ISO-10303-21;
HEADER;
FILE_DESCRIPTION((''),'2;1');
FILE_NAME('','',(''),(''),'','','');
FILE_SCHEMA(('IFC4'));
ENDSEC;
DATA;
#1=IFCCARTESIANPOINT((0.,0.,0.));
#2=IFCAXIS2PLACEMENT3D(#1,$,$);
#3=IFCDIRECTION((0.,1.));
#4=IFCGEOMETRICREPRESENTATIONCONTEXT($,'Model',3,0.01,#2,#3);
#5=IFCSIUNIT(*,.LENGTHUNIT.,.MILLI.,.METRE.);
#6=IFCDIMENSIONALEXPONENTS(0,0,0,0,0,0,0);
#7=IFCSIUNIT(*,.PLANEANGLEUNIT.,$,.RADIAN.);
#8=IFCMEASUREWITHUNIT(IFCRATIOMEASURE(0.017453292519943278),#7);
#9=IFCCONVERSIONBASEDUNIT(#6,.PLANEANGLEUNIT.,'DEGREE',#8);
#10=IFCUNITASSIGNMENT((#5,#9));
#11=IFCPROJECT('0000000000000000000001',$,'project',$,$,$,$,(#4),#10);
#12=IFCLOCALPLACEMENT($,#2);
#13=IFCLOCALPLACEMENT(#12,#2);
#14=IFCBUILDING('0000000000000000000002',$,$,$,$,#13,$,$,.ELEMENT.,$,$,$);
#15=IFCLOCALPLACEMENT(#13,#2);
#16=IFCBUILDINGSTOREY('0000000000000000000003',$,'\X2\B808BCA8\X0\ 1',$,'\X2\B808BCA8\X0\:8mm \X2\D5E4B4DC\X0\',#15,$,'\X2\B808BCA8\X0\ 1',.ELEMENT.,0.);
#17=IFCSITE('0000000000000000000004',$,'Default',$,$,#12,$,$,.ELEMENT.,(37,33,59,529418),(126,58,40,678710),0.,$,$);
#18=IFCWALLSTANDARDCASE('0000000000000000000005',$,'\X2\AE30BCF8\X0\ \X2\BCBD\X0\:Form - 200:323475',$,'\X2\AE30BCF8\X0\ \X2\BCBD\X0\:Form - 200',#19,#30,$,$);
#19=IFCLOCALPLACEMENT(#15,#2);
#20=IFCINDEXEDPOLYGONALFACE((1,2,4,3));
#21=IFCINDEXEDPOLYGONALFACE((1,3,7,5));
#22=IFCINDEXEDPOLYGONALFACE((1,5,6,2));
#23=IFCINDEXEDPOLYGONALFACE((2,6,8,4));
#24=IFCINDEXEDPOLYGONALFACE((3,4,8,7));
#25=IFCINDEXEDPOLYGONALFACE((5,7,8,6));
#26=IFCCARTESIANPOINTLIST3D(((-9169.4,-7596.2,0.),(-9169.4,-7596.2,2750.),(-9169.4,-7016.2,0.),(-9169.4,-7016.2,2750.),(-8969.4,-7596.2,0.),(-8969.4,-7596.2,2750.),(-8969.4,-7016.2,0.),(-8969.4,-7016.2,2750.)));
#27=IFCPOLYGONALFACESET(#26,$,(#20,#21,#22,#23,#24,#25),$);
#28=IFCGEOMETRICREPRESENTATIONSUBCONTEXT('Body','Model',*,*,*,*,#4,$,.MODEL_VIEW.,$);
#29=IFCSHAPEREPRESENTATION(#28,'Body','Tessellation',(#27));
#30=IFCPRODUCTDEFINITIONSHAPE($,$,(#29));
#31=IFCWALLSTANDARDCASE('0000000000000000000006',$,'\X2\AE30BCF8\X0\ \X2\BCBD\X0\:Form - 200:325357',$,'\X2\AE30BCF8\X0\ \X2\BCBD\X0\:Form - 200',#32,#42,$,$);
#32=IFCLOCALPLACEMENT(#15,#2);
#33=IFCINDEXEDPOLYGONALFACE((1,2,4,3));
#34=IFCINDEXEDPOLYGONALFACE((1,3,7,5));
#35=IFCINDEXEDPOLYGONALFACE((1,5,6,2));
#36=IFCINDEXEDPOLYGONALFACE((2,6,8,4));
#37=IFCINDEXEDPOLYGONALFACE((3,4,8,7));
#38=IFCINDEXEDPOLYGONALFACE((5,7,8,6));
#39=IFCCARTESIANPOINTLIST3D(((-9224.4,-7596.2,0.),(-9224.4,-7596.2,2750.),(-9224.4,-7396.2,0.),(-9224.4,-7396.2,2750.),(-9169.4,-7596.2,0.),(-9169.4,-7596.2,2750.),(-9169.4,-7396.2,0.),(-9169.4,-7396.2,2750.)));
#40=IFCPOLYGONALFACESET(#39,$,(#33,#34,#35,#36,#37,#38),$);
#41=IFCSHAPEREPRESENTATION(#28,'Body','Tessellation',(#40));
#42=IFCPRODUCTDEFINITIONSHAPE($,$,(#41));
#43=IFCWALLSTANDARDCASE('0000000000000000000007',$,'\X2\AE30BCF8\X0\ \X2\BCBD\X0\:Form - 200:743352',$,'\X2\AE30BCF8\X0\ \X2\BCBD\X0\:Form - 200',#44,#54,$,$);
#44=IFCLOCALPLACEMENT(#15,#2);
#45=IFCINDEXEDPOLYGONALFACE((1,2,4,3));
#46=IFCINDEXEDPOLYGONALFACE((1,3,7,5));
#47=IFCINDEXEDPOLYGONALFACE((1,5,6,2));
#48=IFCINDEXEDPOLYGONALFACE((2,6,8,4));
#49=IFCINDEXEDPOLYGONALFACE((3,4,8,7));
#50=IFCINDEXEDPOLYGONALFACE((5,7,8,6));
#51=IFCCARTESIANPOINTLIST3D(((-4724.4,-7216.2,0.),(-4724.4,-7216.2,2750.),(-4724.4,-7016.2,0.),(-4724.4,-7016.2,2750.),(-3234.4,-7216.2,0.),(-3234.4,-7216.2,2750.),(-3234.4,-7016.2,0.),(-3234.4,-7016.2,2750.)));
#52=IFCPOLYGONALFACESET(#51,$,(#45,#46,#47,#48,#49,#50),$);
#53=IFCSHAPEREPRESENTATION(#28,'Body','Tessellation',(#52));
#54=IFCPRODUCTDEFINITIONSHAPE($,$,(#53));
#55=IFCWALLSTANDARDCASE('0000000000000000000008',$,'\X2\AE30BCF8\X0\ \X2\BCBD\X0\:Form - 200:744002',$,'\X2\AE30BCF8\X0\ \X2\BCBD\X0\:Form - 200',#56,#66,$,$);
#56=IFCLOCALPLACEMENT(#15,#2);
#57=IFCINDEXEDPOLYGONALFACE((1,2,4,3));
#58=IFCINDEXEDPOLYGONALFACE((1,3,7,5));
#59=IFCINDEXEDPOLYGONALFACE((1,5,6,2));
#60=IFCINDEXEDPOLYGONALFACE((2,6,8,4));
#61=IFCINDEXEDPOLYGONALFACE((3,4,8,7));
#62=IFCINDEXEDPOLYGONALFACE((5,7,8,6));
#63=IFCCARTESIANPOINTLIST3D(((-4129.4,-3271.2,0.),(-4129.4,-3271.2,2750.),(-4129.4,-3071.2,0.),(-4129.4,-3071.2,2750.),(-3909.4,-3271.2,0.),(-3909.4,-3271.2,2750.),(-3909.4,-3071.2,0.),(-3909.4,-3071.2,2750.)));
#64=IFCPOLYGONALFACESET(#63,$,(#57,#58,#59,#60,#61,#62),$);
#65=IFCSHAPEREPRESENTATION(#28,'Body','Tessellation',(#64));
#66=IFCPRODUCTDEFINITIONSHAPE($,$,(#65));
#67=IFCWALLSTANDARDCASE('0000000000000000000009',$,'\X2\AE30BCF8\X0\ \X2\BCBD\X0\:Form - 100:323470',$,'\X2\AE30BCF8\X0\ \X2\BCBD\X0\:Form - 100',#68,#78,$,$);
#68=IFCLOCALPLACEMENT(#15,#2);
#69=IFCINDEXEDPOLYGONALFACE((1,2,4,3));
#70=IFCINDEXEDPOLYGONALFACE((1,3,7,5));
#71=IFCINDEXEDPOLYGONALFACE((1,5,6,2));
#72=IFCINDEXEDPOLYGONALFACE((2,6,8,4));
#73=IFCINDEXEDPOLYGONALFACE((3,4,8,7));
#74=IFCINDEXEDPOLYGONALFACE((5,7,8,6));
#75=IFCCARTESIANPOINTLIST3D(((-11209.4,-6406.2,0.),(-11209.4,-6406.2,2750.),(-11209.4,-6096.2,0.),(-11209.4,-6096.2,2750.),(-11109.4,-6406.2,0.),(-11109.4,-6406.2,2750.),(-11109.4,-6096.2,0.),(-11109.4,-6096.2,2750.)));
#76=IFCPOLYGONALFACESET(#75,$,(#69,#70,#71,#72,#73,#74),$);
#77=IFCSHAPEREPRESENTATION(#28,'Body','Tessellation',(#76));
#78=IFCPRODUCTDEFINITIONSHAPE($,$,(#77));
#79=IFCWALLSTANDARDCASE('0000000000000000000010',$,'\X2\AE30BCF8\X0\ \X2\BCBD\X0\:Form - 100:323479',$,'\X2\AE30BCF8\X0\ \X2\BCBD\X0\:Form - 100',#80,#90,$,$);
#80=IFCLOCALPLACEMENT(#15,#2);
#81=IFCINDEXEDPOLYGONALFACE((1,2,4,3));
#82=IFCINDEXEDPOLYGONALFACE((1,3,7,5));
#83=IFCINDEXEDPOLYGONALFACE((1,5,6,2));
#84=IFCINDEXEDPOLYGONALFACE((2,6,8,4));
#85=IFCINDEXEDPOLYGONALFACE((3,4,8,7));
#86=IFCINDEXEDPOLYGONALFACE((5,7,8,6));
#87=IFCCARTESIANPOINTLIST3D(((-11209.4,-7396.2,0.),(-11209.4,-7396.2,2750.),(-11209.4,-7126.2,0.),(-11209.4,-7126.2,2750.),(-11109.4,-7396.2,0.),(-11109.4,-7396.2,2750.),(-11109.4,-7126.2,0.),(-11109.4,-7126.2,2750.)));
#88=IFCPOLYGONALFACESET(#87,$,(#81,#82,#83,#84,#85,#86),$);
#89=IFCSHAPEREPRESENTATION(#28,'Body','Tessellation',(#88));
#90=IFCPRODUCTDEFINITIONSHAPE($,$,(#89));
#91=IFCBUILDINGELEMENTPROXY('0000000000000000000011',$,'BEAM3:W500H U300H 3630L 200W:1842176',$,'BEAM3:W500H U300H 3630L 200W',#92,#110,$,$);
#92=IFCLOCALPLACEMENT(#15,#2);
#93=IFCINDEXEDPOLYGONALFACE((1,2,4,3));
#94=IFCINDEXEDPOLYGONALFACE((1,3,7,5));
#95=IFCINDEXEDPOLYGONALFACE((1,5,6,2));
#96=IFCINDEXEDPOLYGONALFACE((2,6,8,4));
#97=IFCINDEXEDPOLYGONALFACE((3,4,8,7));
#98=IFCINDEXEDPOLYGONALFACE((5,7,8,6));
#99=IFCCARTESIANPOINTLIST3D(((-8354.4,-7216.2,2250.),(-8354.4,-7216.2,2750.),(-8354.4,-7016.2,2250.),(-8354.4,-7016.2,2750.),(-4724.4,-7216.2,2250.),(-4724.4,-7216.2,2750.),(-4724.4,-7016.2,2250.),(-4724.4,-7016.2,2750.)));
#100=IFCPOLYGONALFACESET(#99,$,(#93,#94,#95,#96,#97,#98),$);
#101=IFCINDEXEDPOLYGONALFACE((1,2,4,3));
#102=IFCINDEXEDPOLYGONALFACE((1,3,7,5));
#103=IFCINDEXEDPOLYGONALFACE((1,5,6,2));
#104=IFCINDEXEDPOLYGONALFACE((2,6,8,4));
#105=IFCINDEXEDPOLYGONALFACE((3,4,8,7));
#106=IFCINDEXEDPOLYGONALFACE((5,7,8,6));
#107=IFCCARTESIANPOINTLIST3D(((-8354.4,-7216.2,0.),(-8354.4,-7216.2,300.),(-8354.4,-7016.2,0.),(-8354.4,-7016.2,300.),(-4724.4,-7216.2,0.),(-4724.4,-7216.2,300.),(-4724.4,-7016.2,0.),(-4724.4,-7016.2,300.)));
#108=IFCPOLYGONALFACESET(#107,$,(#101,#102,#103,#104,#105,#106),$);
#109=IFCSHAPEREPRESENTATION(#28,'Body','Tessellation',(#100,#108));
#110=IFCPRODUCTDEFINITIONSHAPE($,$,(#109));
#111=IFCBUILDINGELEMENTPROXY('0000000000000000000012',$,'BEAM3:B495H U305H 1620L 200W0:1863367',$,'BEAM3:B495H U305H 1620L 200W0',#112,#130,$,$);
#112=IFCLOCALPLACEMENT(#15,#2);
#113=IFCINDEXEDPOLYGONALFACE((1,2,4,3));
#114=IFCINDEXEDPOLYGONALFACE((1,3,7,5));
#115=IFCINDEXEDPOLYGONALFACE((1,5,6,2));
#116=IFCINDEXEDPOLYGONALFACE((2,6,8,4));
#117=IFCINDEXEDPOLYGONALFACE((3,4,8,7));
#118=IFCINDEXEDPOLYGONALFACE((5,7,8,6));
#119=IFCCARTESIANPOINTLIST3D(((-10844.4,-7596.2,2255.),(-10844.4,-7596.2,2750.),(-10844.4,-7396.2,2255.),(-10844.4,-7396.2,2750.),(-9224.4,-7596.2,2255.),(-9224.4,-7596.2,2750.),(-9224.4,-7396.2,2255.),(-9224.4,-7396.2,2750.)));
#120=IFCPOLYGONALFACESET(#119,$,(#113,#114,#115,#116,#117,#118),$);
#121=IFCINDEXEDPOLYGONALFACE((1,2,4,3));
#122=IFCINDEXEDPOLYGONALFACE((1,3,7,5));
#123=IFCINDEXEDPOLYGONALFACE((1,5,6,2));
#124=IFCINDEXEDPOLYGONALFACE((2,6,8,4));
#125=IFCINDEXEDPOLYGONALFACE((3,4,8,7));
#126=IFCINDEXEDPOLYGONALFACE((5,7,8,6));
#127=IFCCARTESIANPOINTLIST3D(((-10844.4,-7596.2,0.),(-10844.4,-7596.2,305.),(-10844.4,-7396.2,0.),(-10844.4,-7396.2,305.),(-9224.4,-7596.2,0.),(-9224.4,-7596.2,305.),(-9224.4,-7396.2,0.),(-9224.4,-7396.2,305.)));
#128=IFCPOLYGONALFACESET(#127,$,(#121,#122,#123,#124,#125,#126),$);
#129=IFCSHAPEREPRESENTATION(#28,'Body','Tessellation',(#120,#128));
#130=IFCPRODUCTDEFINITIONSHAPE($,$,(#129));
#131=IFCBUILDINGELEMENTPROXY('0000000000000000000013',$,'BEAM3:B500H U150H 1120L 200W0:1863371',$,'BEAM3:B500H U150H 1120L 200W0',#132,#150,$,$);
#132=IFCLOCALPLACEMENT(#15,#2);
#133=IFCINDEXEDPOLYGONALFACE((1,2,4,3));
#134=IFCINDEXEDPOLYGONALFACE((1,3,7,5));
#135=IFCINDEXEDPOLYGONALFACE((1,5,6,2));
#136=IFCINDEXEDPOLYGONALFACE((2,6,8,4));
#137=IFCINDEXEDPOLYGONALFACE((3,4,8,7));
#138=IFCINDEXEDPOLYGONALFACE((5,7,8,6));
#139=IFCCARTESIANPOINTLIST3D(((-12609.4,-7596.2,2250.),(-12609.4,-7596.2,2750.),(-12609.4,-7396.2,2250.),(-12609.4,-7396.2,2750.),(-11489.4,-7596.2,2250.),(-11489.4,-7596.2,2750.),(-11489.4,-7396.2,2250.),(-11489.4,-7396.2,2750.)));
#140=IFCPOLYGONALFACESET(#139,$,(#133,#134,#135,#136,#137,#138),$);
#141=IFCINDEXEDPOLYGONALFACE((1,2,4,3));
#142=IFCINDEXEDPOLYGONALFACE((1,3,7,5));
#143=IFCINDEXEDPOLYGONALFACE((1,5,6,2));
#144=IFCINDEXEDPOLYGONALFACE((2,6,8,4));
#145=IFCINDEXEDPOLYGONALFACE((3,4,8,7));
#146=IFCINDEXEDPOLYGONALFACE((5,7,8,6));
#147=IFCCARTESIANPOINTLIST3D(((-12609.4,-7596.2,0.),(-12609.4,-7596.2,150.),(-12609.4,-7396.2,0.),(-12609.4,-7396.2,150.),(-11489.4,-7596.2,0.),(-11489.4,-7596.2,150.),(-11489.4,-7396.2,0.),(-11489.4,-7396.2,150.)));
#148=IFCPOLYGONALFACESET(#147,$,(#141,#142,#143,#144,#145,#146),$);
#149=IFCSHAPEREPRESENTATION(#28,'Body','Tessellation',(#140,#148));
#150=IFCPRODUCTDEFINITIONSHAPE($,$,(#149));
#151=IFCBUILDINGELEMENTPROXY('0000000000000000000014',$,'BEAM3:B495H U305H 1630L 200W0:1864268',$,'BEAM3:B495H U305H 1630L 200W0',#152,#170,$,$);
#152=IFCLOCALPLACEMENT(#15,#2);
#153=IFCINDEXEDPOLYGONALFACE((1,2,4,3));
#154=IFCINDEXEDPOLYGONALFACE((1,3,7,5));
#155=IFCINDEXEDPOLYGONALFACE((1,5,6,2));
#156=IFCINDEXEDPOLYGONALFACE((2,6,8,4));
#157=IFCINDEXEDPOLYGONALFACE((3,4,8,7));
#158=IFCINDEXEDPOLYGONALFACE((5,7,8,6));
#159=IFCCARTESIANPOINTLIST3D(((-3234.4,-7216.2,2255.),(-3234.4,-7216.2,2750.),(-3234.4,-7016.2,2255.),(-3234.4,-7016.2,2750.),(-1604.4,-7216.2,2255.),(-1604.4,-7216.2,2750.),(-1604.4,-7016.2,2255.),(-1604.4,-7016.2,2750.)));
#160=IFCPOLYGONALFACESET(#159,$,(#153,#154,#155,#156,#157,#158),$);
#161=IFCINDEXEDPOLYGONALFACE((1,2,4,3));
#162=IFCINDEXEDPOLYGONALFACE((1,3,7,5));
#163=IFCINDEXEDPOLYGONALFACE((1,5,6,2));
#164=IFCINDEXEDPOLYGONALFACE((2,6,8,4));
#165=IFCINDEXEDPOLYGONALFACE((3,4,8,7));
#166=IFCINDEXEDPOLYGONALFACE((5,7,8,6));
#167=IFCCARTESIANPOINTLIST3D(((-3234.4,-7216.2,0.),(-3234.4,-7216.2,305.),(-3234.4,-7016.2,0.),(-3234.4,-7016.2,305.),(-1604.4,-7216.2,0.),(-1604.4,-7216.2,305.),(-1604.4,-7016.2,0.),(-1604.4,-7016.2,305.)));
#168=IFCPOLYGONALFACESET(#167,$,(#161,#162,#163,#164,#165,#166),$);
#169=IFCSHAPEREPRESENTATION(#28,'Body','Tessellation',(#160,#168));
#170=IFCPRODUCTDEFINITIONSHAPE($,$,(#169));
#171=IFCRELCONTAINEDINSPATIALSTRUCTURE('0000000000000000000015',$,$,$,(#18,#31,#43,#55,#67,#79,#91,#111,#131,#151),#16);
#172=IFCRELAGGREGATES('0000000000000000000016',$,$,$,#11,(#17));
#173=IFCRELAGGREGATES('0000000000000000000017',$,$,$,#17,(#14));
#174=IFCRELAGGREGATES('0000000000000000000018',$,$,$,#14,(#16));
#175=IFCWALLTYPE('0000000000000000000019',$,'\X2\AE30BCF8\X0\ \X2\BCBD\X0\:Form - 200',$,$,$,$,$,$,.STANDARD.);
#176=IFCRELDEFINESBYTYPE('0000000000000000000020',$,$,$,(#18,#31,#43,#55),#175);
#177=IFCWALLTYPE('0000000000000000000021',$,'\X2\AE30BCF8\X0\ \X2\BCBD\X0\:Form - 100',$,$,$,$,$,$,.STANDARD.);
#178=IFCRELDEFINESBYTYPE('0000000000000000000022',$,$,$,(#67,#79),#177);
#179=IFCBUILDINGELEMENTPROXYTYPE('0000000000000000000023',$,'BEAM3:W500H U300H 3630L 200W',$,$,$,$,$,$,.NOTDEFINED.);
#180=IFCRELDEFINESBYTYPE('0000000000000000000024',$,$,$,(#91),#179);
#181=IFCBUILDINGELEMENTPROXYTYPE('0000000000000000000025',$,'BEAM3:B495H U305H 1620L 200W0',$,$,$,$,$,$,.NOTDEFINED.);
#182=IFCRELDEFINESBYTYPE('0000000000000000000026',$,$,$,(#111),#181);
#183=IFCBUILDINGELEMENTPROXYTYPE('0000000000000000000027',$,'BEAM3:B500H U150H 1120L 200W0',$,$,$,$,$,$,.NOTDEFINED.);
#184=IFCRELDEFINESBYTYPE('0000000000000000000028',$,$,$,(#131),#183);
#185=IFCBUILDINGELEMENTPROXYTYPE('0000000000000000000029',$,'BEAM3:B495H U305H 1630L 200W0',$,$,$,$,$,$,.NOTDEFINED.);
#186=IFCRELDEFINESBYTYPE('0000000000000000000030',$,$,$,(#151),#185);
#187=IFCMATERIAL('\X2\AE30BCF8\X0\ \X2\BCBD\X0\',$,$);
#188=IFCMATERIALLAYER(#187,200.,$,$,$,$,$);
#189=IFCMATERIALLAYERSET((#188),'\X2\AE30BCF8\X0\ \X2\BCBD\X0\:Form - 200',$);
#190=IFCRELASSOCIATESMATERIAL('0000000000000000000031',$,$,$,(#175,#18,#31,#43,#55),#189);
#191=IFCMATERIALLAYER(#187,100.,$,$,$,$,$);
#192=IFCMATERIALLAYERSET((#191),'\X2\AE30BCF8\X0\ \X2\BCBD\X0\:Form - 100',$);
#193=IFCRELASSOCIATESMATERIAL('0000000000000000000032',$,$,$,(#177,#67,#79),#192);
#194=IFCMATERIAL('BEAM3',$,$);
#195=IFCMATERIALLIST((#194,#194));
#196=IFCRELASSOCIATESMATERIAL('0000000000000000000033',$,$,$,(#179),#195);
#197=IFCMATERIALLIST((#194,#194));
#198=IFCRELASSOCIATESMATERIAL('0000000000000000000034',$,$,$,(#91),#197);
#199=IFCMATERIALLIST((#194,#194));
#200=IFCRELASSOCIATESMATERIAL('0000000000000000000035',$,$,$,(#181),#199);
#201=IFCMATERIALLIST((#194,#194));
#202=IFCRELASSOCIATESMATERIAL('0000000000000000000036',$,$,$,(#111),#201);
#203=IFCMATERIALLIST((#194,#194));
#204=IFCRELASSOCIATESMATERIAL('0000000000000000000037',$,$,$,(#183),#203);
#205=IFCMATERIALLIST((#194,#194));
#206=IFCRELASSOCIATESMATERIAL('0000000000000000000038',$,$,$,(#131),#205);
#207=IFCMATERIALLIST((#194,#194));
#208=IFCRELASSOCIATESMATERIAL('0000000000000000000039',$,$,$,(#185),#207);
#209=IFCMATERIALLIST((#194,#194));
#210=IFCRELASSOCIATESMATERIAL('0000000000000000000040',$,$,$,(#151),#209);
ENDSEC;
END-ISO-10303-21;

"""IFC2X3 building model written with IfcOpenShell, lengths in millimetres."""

from ifc_helpers import new_model, entity, si_unit, converted_unit, direction, frame, frame_2d, origin, origin_2d_with_axis, place, context, subcontext, project, spatial, rectangle, extrude, source, transform, mapped, material, material_list, layer, layer_set, layer_usage, type_object, type_shapes, element, save


model = new_model("IFC2X3")

# Units and contexts
model_context = context("Model", 3, precision=0.01, world=origin(), true_north=direction((0.0, 1.0)))
body_context = subcontext(model_context, "Body", "Model", "MODEL_VIEW")
ifc_project = project(units=[si_unit("LENGTHUNIT", "METRE", prefix="MILLI"), converted_unit("PLANEANGLEUNIT", "DEGREE", entity("IfcRatioMeasure", 0.017453292519943278), si_unit("PLANEANGLEUNIT", "RADIAN"), dimensions=[0, 0, 0, 0, 0, 0, 0])], contexts=[model_context])

# Site, building, storey
site_placement = place(None, origin())
site = spatial("IfcSite", under=ifc_project, at=site_placement, Name="Default", CompositionType="ELEMENT", RefLatitude=(37, 33, 59, 529418), RefLongitude=(126, 58, 40, 678710), RefElevation=0.0)
building_placement = place(site_placement, origin())
building = spatial("IfcBuilding", under=site, at=building_placement, CompositionType="ELEMENT")
storey_placement = place(building_placement, origin())
storey = spatial("IfcBuildingStorey", under=building, at=storey_placement, Name="레벨 1", ObjectType="레벨:8mm 헤드", LongName="레벨 1", CompositionType="ELEMENT", Elevation=0.0)

# Walls
ifc_material_1 = material(Name="기본 벽")
ifc_layer_1 = layer(ifc_material_1, 200.0)
ifc_layer_set_1 = layer_set([ifc_layer_1], Name="기본 벽:Form - 200")
wall_type_1 = type_object("IfcWallType", Name="기본 벽:Form - 200", PredefinedType="STANDARD", material=ifc_layer_set_1)
ifc_layer_usage_1 = layer_usage(ifc_layer_set_1, "AXIS2", "POSITIVE", -100.0)
wall_1_placement = place(storey_placement, frame((-9069.4, -7596.2, 0.0), z_axis=(0.0, 0.0, 1.0), x_axis=(0.0, 1.0, 0.0)))
element("IfcWallStandardCase", 1, at=wall_1_placement, inside=storey, type_object=wall_type_1, material=ifc_layer_usage_1, Name="기본 벽:Form - 200:323475", ObjectType="기본 벽:Form - 200", context=body_context, shape_type="SweptSolid", body=[
    extrude(rectangle(XDim=580.0, YDim=200.0, at=frame_2d((290.0, 0.0), x_axis=(-1.0, 0.0))), origin(), (0.0, 0.0, 1.0), 2750.0),
])
ifc_layer_usage_2 = layer_usage(ifc_layer_set_1, "AXIS2", "POSITIVE", -100.0)
wall_2_placement = place(storey_placement, frame((-9224.4, -7496.2, 0.0)))
element("IfcWallStandardCase", 2, at=wall_2_placement, inside=storey, type_object=wall_type_1, material=ifc_layer_usage_2, Name="기본 벽:Form - 200:325357", ObjectType="기본 벽:Form - 200", context=body_context, shape_type="SweptSolid", body=[
    extrude(rectangle(XDim=55.0, YDim=200.0, at=frame_2d((27.5, 0.0), x_axis=(-1.0, 0.0))), origin(), (0.0, 0.0, 1.0), 2750.0),
])
ifc_layer_usage_3 = layer_usage(ifc_layer_set_1, "AXIS2", "POSITIVE", -100.0)
wall_3_placement = place(storey_placement, frame((-4724.4, -7116.2, 0.0)))
element("IfcWallStandardCase", 3, at=wall_3_placement, inside=storey, type_object=wall_type_1, material=ifc_layer_usage_3, Name="기본 벽:Form - 200:743352", ObjectType="기본 벽:Form - 200", context=body_context, shape_type="SweptSolid", body=[
    extrude(rectangle(XDim=1490.0, YDim=200.0, at=frame_2d((745.0, 0.0), x_axis=(-1.0, 0.0))), origin(), (0.0, 0.0, 1.0), 2750.0),
])
ifc_layer_usage_4 = layer_usage(ifc_layer_set_1, "AXIS2", "POSITIVE", -100.0)
wall_4_placement = place(storey_placement, frame((-3909.4, -3171.2, 0.0), z_axis=(0.0, 0.0, 1.0), x_axis=(-1.0, 0.0, 0.0)))
element("IfcWallStandardCase", 4, at=wall_4_placement, inside=storey, type_object=wall_type_1, material=ifc_layer_usage_4, Name="기본 벽:Form - 200:744002", ObjectType="기본 벽:Form - 200", context=body_context, shape_type="SweptSolid", body=[
    extrude(rectangle(XDim=220.0, YDim=200.0, at=frame_2d((110.0, 0.0), x_axis=(-1.0, 0.0))), origin(), (0.0, 0.0, 1.0), 2750.0),
])
ifc_layer_2 = layer(ifc_material_1, 100.0)
ifc_layer_set_2 = layer_set([ifc_layer_2], Name="기본 벽:Form - 100")
ifc_layer_usage_5 = layer_usage(ifc_layer_set_2, "AXIS2", "POSITIVE", -50.0)
wall_type_2 = type_object("IfcWallType", Name="기본 벽:Form - 100", PredefinedType="STANDARD", material=ifc_layer_set_2)
wall_5_placement = place(storey_placement, frame((-11159.4, -6096.2, 0.0), z_axis=(0.0, 0.0, 1.0), x_axis=(0.0, -1.0, 0.0)))
element("IfcWallStandardCase", 5, at=wall_5_placement, inside=storey, type_object=wall_type_2, material=ifc_layer_usage_5, Name="기본 벽:Form - 100:323470", ObjectType="기본 벽:Form - 100", context=body_context, shape_type="SweptSolid", body=[
    extrude(rectangle(XDim=310.0, YDim=100.0, at=frame_2d((155.0, 0.0), x_axis=(-1.0, 0.0))), origin(), (0.0, 0.0, 1.0), 2750.0),
])
ifc_layer_usage_6 = layer_usage(ifc_layer_set_2, "AXIS2", "POSITIVE", -50.0)
wall_6_placement = place(storey_placement, frame((-11159.4, -7396.2, 0.0), z_axis=(0.0, 0.0, 1.0), x_axis=(0.0, 1.0, 0.0)))
element("IfcWallStandardCase", 6, at=wall_6_placement, inside=storey, type_object=wall_type_2, material=ifc_layer_usage_6, Name="기본 벽:Form - 100:323479", ObjectType="기본 벽:Form - 100", context=body_context, shape_type="SweptSolid", body=[
    extrude(rectangle(XDim=270.0, YDim=100.0, at=frame_2d((135.0, 0.0), x_axis=(-1.0, 0.0))), origin(), (0.0, 0.0, 1.0), 2750.0),
])

# Building element proxies
ifc_material_2 = material(Name="BEAM3")
ifc_material_list_1 = material_list([ifc_material_2, ifc_material_2])
ifc_material_list_2 = material_list([ifc_material_2, ifc_material_2])
building_element_proxy_type_1 = type_object("IfcBuildingElementProxyType", Name="BEAM3:W500H U300H 3630L 200W", PredefinedType="NOTDEFINED", material=ifc_material_list_2)
shared_shape_1 = source(origin(), body_context, "Body", "SweptSolid", [
    extrude(rectangle(XDim=3630.0, YDim=200.0, at=origin_2d_with_axis()), frame((1815.0, -100.0, 2250.0)), (0.0, 0.0, 1.0), 500.0),
    extrude(rectangle(XDim=3630.0, YDim=200.0, at=origin_2d_with_axis()), frame((1815.0, -100.0, 0.0)), (0.0, 0.0, 1.0), 300.0),
])
type_shapes(building_element_proxy_type_1, [shared_shape_1])
proxy_1_placement = place(storey_placement, frame((-4724.4, -7216.2, 0.0), z_axis=(0.0, 0.0, 1.0), x_axis=(-1.0, 0.0, 0.0)))
element("IfcBuildingElementProxy", 7, at=proxy_1_placement, inside=storey, type_object=building_element_proxy_type_1, material=ifc_material_list_1, Name="BEAM3:W500H U300H 3630L 200W:1842176", ObjectType="BEAM3:W500H U300H 3630L 200W", context=body_context, shape_type="MappedRepresentation", body=[
    mapped(shared_shape_1, transform((0.0, 0.0, 0.0), scale=1.0)),
])
ifc_material_list_3 = material_list([ifc_material_2, ifc_material_2])
ifc_material_list_4 = material_list([ifc_material_2, ifc_material_2])
building_element_proxy_type_2 = type_object("IfcBuildingElementProxyType", Name="BEAM3:B495H U305H 1620L 200W0", PredefinedType="NOTDEFINED", material=ifc_material_list_4)
shared_shape_2 = source(origin(), body_context, "Body", "SweptSolid", [
    extrude(rectangle(XDim=1620.0, YDim=200.0, at=origin_2d_with_axis()), frame((810.0, -100.0, 2255.0)), (0.0, 0.0, 1.0), 495.0),
    extrude(rectangle(XDim=1620.0, YDim=200.0, at=origin_2d_with_axis()), frame((810.0, -100.0, 0.0)), (0.0, 0.0, 1.0), 305.0),
])
type_shapes(building_element_proxy_type_2, [shared_shape_2])
proxy_2_placement = place(storey_placement, frame((-9224.4, -7596.2, 0.0), z_axis=(0.0, 0.0, 1.0), x_axis=(-1.0, 0.0, 0.0)))
element("IfcBuildingElementProxy", 8, at=proxy_2_placement, inside=storey, type_object=building_element_proxy_type_2, material=ifc_material_list_3, Name="BEAM3:B495H U305H 1620L 200W0:1863367", ObjectType="BEAM3:B495H U305H 1620L 200W0", context=body_context, shape_type="MappedRepresentation", body=[
    mapped(shared_shape_2, transform((0.0, 0.0, 0.0), scale=1.0)),
])
ifc_material_list_5 = material_list([ifc_material_2, ifc_material_2])
ifc_material_list_6 = material_list([ifc_material_2, ifc_material_2])
building_element_proxy_type_3 = type_object("IfcBuildingElementProxyType", Name="BEAM3:B500H U150H 1120L 200W0", PredefinedType="NOTDEFINED", material=ifc_material_list_6)
shared_shape_3 = source(origin(), body_context, "Body", "SweptSolid", [
    extrude(rectangle(XDim=1120.0, YDim=200.0, at=origin_2d_with_axis()), frame((560.0, -100.0, 2250.0)), (0.0, 0.0, 1.0), 500.0),
    extrude(rectangle(XDim=1120.0, YDim=200.0, at=origin_2d_with_axis()), frame((560.0, -100.0, 0.0)), (0.0, 0.0, 1.0), 150.0),
])
type_shapes(building_element_proxy_type_3, [shared_shape_3])
proxy_3_placement = place(storey_placement, frame((-12609.4, -7396.2, 0.0)))
element("IfcBuildingElementProxy", 9, at=proxy_3_placement, inside=storey, type_object=building_element_proxy_type_3, material=ifc_material_list_5, Name="BEAM3:B500H U150H 1120L 200W0:1863371", ObjectType="BEAM3:B500H U150H 1120L 200W0", context=body_context, shape_type="MappedRepresentation", body=[
    mapped(shared_shape_3, transform((0.0, 0.0, 0.0), scale=1.0)),
])
ifc_material_list_7 = material_list([ifc_material_2, ifc_material_2])
ifc_material_list_8 = material_list([ifc_material_2, ifc_material_2])
building_element_proxy_type_4 = type_object("IfcBuildingElementProxyType", Name="BEAM3:B495H U305H 1630L 200W0", PredefinedType="NOTDEFINED", material=ifc_material_list_8)
shared_shape_4 = source(origin(), body_context, "Body", "SweptSolid", [
    extrude(rectangle(XDim=1630.0, YDim=200.0, at=origin_2d_with_axis()), frame((815.0, -100.0, 2255.0)), (0.0, 0.0, 1.0), 495.0),
    extrude(rectangle(XDim=1630.0, YDim=200.0, at=origin_2d_with_axis()), frame((815.0, -100.0, 0.0)), (0.0, 0.0, 1.0), 305.0),
])
type_shapes(building_element_proxy_type_4, [shared_shape_4])
proxy_4_placement = place(storey_placement, frame((-3234.4, -7016.2, 0.0)))
element("IfcBuildingElementProxy", 10, at=proxy_4_placement, inside=storey, type_object=building_element_proxy_type_4, material=ifc_material_list_7, Name="BEAM3:B495H U305H 1630L 200W0:1864268", ObjectType="BEAM3:B495H U305H 1630L 200W0", context=body_context, shape_type="MappedRepresentation", body=[
    mapped(shared_shape_4, transform((0.0, 0.0, 0.0), scale=1.0)),
])

save(model, "model.ifc")
